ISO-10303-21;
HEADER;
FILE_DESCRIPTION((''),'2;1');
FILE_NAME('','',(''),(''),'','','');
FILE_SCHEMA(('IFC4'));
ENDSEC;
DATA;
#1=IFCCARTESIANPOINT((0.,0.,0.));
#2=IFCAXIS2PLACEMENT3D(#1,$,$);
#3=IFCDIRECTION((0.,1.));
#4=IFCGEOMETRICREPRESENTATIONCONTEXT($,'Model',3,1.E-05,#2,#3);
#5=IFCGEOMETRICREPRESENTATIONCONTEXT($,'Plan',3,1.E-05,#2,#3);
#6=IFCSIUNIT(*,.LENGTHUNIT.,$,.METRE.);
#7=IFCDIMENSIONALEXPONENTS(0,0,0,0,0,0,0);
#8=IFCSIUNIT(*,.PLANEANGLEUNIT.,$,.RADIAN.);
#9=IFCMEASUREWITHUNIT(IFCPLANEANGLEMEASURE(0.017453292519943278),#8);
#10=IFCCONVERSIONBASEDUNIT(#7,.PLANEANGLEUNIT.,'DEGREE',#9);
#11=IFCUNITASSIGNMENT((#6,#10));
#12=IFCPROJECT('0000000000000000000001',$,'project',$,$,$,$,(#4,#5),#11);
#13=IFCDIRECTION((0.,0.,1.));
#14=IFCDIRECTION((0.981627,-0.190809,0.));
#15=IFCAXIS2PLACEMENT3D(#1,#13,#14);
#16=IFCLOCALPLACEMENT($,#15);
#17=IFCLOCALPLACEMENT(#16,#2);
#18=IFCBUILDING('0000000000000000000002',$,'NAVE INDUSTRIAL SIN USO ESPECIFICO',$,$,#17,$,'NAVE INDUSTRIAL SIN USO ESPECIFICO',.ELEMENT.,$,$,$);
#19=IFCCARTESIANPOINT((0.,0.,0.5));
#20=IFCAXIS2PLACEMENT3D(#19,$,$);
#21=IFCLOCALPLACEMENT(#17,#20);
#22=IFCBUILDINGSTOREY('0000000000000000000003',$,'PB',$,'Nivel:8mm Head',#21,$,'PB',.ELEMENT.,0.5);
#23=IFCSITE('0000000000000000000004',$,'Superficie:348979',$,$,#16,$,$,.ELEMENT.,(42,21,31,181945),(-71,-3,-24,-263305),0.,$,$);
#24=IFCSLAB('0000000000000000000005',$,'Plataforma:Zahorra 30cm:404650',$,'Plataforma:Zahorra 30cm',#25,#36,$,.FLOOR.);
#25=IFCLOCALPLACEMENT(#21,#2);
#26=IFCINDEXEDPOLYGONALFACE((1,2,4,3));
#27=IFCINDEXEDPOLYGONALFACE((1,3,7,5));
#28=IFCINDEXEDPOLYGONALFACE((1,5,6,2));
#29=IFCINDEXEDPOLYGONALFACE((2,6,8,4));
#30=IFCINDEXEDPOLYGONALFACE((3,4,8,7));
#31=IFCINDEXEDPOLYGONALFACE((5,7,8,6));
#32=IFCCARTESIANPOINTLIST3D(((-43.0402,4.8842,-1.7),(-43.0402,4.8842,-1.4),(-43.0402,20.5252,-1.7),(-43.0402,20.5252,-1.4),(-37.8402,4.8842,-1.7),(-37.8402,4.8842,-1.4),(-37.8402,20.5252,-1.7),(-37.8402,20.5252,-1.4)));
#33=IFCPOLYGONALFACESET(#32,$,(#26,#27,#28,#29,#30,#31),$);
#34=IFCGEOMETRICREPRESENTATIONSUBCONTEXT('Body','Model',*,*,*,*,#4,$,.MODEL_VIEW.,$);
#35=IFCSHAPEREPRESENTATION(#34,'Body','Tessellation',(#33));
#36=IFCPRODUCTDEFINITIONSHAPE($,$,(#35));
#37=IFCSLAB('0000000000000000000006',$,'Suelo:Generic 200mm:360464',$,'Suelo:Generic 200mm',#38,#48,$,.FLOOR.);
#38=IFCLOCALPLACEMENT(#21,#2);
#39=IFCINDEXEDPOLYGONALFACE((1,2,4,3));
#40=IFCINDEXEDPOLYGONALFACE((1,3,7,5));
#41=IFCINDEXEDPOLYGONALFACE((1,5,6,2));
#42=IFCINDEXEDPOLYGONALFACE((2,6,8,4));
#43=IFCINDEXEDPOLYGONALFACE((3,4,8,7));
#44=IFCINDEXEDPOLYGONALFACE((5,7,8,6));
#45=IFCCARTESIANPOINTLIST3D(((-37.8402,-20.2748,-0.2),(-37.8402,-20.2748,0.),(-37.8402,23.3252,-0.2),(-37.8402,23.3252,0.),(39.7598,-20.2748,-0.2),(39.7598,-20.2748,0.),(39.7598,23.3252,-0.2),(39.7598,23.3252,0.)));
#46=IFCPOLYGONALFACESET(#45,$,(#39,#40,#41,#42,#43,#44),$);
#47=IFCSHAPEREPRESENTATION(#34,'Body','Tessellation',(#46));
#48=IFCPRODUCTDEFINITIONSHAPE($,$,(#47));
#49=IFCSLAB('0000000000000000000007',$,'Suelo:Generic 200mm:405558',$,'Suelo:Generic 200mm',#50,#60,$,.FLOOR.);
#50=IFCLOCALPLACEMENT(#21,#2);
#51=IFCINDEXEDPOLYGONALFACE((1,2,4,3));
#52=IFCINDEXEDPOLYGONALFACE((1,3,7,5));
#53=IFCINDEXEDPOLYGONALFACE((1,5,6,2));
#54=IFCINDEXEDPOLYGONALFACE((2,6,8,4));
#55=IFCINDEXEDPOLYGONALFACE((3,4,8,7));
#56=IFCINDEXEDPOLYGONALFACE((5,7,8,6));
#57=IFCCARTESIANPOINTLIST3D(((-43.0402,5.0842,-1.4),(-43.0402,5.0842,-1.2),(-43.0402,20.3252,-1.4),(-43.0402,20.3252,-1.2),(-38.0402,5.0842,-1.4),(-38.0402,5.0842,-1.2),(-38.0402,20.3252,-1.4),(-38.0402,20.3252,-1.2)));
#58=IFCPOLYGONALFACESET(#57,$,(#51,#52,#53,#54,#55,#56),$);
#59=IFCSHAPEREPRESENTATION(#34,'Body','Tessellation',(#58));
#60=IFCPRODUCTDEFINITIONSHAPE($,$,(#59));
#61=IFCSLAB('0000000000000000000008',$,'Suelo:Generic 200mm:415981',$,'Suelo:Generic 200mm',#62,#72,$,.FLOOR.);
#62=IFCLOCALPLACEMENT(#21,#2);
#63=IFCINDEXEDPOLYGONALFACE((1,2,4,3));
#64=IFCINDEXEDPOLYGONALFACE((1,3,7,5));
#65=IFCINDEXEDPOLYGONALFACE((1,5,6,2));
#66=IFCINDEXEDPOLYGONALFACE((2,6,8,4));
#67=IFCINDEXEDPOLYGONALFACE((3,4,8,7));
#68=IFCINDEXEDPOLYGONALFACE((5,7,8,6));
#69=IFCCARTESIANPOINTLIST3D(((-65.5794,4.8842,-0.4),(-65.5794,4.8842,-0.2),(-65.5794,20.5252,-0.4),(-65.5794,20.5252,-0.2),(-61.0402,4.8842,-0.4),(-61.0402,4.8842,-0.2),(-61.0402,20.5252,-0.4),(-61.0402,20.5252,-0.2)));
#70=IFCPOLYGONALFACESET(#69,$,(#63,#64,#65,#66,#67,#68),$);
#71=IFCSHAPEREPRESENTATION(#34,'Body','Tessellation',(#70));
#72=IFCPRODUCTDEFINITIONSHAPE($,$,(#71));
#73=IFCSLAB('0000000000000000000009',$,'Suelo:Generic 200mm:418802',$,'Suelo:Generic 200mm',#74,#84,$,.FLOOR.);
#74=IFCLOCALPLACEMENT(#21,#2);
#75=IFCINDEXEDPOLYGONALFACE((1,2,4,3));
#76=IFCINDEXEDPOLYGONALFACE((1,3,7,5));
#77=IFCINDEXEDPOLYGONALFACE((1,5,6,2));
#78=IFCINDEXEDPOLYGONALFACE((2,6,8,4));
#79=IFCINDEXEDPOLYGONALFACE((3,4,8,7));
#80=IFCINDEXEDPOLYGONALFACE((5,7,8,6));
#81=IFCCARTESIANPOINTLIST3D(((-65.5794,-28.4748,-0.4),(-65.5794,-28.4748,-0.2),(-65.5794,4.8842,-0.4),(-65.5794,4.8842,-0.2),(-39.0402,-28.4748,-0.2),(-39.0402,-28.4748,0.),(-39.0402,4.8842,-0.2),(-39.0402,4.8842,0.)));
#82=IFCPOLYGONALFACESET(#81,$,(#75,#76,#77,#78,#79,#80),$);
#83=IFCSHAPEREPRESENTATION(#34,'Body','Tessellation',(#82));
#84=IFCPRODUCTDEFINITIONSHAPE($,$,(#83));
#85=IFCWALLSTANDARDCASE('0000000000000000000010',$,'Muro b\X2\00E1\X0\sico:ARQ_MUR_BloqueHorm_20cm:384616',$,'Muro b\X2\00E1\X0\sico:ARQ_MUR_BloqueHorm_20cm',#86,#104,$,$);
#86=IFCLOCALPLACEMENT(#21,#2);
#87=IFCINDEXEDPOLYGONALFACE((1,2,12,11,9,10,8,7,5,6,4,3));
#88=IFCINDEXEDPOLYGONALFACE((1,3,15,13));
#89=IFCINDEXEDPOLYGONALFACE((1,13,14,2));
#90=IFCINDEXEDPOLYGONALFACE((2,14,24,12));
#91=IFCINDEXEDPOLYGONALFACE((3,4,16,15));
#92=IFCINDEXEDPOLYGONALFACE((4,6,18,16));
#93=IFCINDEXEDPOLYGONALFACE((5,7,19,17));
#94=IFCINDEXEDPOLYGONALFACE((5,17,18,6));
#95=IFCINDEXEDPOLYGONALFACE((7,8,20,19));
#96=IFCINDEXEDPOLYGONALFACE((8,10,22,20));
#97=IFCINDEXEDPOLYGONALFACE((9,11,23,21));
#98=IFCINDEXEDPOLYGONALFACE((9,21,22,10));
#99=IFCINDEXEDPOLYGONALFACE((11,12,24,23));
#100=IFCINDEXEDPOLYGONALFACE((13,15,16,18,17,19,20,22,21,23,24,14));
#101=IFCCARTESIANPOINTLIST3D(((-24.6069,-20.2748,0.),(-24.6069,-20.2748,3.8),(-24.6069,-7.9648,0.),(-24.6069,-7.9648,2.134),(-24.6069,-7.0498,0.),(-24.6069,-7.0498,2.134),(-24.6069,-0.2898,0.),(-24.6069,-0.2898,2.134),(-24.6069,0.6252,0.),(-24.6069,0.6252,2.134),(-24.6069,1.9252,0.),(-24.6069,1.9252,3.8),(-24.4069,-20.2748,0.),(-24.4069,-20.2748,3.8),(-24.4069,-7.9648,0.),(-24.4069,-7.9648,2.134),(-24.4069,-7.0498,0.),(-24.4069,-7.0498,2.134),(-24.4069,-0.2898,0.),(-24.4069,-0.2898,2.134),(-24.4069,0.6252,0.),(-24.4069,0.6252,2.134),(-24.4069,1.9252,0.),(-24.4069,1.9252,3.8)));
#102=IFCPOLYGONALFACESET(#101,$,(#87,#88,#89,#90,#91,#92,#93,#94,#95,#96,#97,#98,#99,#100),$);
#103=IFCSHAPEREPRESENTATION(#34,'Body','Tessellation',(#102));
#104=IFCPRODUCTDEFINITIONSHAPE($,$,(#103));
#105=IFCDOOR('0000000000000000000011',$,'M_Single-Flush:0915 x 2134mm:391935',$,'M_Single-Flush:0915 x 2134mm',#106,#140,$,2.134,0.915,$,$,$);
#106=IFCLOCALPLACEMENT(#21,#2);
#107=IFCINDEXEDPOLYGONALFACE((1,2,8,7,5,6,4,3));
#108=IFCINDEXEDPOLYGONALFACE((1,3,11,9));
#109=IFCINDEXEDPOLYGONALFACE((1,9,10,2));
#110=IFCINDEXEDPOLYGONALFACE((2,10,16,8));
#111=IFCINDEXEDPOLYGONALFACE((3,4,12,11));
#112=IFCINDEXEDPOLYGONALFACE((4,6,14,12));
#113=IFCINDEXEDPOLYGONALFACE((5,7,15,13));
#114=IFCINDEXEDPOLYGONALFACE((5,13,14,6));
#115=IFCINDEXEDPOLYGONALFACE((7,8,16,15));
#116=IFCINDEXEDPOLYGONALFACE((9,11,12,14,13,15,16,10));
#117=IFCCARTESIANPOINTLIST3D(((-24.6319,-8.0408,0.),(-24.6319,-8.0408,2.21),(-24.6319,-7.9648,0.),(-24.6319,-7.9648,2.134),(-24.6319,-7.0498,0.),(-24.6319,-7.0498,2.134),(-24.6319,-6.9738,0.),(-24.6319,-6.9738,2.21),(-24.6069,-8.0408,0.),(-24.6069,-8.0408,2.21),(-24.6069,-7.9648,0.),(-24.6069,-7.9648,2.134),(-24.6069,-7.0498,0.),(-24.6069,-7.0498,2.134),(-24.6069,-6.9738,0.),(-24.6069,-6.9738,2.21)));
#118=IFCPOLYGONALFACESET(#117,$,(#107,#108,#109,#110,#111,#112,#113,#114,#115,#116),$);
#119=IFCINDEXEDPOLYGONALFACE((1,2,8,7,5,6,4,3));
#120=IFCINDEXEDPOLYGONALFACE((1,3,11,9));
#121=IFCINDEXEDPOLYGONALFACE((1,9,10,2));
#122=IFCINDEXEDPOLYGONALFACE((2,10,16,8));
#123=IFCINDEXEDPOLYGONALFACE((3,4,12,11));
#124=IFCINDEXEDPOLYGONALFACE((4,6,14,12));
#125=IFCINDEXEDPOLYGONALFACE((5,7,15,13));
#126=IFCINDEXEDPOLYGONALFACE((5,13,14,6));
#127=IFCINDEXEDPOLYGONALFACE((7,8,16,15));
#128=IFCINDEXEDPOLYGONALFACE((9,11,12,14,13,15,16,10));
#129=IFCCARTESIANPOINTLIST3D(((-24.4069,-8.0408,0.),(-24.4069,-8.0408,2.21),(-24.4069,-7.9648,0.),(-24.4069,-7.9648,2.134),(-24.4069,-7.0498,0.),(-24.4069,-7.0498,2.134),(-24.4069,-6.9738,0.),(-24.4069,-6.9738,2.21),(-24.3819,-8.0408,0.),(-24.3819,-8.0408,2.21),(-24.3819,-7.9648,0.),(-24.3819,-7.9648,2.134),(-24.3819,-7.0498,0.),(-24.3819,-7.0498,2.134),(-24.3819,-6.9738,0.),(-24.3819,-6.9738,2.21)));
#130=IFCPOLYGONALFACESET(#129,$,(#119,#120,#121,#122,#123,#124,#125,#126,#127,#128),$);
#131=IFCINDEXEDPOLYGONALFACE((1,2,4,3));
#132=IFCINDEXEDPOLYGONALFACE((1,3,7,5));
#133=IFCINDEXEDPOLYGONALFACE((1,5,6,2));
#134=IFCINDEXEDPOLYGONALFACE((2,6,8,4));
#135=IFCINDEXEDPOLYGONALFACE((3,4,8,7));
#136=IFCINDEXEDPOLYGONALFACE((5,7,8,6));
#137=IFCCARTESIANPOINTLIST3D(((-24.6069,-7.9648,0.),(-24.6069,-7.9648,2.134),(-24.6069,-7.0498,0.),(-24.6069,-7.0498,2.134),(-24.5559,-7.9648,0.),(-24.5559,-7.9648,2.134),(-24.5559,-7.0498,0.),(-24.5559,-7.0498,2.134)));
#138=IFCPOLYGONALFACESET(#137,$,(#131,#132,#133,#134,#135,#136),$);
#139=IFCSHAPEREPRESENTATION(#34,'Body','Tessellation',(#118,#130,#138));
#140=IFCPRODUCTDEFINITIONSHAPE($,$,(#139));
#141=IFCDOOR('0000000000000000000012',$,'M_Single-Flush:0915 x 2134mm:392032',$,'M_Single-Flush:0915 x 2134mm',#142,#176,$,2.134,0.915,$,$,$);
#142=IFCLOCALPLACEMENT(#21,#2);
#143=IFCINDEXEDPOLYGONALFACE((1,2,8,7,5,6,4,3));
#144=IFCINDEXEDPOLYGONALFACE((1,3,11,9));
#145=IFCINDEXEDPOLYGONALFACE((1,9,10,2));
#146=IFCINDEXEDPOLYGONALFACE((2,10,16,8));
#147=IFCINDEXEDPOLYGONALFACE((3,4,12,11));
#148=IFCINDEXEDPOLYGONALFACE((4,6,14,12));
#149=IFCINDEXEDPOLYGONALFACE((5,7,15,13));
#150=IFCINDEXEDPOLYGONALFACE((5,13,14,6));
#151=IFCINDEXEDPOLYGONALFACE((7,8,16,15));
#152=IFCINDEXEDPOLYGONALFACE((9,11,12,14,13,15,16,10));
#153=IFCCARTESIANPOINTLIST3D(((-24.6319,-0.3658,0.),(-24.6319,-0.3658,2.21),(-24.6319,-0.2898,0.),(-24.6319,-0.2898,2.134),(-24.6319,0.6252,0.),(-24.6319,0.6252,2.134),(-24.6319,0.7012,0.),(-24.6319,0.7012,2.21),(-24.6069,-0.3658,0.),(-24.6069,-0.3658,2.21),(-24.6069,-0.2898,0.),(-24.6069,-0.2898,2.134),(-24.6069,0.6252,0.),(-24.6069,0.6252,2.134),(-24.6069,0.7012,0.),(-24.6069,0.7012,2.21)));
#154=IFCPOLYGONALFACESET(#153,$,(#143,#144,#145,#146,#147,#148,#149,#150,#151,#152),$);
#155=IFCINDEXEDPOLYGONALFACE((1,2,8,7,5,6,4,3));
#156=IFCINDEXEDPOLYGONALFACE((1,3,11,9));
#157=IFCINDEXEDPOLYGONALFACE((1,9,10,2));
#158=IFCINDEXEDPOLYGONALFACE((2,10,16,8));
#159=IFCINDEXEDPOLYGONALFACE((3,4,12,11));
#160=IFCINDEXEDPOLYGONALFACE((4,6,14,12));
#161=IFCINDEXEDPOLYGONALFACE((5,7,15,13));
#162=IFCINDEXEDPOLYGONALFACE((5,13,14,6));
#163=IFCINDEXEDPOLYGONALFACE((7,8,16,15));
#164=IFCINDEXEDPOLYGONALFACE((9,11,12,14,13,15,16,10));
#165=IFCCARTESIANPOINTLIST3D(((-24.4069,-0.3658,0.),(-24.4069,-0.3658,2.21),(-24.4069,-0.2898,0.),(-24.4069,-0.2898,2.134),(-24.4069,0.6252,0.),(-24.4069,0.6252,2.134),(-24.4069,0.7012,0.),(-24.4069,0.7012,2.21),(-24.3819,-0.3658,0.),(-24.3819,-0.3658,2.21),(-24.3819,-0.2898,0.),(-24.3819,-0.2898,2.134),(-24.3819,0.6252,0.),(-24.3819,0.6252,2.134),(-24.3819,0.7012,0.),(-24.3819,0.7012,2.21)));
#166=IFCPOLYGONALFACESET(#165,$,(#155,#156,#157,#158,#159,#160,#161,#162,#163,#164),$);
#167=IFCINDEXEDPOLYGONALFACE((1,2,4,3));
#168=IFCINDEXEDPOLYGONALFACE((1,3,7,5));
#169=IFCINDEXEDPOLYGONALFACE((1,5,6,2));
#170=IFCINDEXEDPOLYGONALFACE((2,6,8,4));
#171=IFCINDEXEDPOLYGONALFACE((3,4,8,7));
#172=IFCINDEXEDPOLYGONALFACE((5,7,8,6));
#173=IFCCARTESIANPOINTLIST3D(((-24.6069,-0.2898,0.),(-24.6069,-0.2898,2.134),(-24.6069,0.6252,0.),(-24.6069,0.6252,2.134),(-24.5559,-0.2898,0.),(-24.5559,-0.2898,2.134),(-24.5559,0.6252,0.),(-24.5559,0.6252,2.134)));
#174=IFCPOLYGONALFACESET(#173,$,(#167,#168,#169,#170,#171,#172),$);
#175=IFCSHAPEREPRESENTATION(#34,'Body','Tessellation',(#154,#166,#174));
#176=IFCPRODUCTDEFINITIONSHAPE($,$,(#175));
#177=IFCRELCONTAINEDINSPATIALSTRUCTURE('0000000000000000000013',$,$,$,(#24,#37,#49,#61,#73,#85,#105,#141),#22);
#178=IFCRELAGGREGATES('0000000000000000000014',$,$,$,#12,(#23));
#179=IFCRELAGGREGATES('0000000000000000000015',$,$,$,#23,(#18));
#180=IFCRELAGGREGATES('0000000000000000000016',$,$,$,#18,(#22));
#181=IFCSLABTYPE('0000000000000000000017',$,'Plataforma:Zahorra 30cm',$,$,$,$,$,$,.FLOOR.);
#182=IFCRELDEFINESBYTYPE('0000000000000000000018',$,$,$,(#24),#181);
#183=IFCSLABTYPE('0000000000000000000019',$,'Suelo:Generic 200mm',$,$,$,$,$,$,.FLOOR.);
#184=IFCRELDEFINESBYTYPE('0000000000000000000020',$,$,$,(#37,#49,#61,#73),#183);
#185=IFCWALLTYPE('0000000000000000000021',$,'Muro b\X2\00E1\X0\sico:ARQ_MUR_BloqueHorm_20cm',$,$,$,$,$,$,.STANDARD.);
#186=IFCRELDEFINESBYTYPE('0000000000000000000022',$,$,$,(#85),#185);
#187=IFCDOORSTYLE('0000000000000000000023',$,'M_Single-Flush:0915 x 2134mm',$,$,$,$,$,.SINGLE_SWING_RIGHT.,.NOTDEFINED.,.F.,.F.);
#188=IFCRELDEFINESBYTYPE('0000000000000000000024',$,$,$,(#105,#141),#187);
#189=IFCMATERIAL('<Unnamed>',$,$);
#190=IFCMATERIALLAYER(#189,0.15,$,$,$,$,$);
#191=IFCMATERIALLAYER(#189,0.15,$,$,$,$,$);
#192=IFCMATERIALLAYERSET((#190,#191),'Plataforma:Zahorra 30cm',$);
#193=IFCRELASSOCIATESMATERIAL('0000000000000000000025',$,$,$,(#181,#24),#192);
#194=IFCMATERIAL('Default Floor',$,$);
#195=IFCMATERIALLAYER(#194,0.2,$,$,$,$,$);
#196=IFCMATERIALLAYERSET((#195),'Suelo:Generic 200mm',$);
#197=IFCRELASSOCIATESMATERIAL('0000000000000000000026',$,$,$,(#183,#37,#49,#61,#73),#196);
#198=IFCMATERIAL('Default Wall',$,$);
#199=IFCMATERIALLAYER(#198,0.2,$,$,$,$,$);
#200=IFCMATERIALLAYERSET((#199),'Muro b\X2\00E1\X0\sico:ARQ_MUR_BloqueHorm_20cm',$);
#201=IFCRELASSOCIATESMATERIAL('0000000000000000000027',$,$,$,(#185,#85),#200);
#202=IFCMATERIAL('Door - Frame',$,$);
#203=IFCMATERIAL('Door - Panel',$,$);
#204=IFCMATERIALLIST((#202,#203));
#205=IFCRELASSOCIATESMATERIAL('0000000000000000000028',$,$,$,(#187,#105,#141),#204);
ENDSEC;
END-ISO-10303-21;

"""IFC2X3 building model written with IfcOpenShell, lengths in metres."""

from ifc_helpers import new_model, entity, si_unit, converted_unit, direction, frame, frame_2d, origin, origin_2d_with_axis, place, context, subcontext, project, spatial, polyline, rectangle, outline, extrude, clip, halfspace, source, transform, mapped, material, material_list, layer, layer_set, layer_usage, type_object, type_shapes, element, fill, save


model = new_model("IFC2X3")

# Units and contexts
model_context = context("Model", 3, precision=1e-05, world=origin(), true_north=direction((0.0, 1.0)))
plan_context = context("Plan", 3, precision=1e-05, world=origin(), true_north=direction((0.0, 1.0)))
body_context = subcontext(model_context, "Body", "Model", "MODEL_VIEW")
ifc_project = project(units=[si_unit("LENGTHUNIT", "METRE"), converted_unit("PLANEANGLEUNIT", "DEGREE", entity("IfcPlaneAngleMeasure", 0.017453292519943278), si_unit("PLANEANGLEUNIT", "RADIAN"), dimensions=[0, 0, 0, 0, 0, 0, 0])], contexts=[model_context, plan_context])

# Site, building, storey
site_placement = place(None, frame((0.0, 0.0, 0.0), z_axis=(0.0, 0.0, 1.0), x_axis=(0.981627, -0.190809, 0.0)))
site = spatial("IfcSite", under=ifc_project, at=site_placement, Name="Superficie:348979", CompositionType="ELEMENT", RefLatitude=(42, 21, 31, 181945), RefLongitude=(-71, -3, -24, -263305), RefElevation=0.0)
building_placement = place(site_placement, origin())
building = spatial("IfcBuilding", under=site, at=building_placement, Name="NAVE INDUSTRIAL SIN USO ESPECIFICO", LongName="NAVE INDUSTRIAL SIN USO ESPECIFICO", CompositionType="ELEMENT")
storey_placement = place(building_placement, frame((0.0, 0.0, 0.5)))
storey = spatial("IfcBuildingStorey", under=building, at=storey_placement, Name="PB", ObjectType="Nivel:8mm Head", LongName="PB", CompositionType="ELEMENT", Elevation=0.5)

# Slabs
ifc_material_1 = material(Name="<Unnamed>")
ifc_layer_1 = layer(ifc_material_1, 0.15)
ifc_layer_2 = layer(ifc_material_1, 0.15)
ifc_layer_set_1 = layer_set([ifc_layer_1, ifc_layer_2], Name="Plataforma:Zahorra 30cm")
slab_type_1 = type_object("IfcSlabType", Name="Plataforma:Zahorra 30cm", PredefinedType="FLOOR", material=ifc_layer_set_1)
ifc_layer_usage_1 = layer_usage(ifc_layer_set_1, "AXIS3", "NEGATIVE", 0.0)
slab_1_placement = place(storey_placement, origin())
element("IfcSlab", 1, at=slab_1_placement, inside=storey, type_object=slab_type_1, material=ifc_layer_usage_1, Name="Plataforma:Zahorra 30cm:404650", ObjectType="Plataforma:Zahorra 30cm", PredefinedType="FLOOR", context=body_context, shape_type="SweptSolid", body=[
    extrude(rectangle(XDim=15.641, YDim=5.2, at=frame_2d((0.0, 0.0), x_axis=(1.0, 0.0))), frame((-40.4402, 12.7047, -1.7), z_axis=(0.0, 0.0, 1.0), x_axis=(0.0, -1.0, 0.0)), (0.0, 0.0, 1.0), 0.3),
])
ifc_material_2 = material(Name="Default Floor")
ifc_layer_3 = layer(ifc_material_2, 0.2)
ifc_layer_set_2 = layer_set([ifc_layer_3], Name="Suelo:Generic 200mm")
ifc_layer_usage_2 = layer_usage(ifc_layer_set_2, "AXIS3", "POSITIVE", 0.0)
slab_type_2 = type_object("IfcSlabType", Name="Suelo:Generic 200mm", PredefinedType="FLOOR", material=ifc_layer_set_2)
slab_2_placement = place(storey_placement, origin())
element("IfcSlab", 2, at=slab_2_placement, inside=storey, type_object=slab_type_2, material=ifc_layer_usage_2, Name="Suelo:Generic 200mm:360464", ObjectType="Suelo:Generic 200mm", PredefinedType="FLOOR", context=body_context, shape_type="SweptSolid", body=[
    extrude(rectangle(XDim=43.6, YDim=77.6, at=origin_2d_with_axis()), frame((0.9598, 1.5252, 0.0), z_axis=(0.0, 0.0, -1.0), x_axis=(0.0, 1.0, 0.0)), (0.0, 0.0, 1.0), 0.2),
])
ifc_layer_usage_3 = layer_usage(ifc_layer_set_2, "AXIS3", "POSITIVE", 0.0)
slab_3_placement = place(storey_placement, origin())
element("IfcSlab", 3, at=slab_3_placement, inside=storey, type_object=slab_type_2, material=ifc_layer_usage_3, Name="Suelo:Generic 200mm:405558", ObjectType="Suelo:Generic 200mm", PredefinedType="FLOOR", context=body_context, shape_type="SweptSolid", body=[
    extrude(rectangle(XDim=15.241, YDim=5.0, at=frame_2d((0.0, 0.0), x_axis=(1.0, 0.0))), frame((-40.5402, 12.7047, -1.2), z_axis=(0.0, 0.0, -1.0), x_axis=(0.0, 1.0, 0.0)), (0.0, 0.0, 1.0), 0.2),
])
ifc_layer_usage_4 = layer_usage(ifc_layer_set_2, "AXIS3", "POSITIVE", 0.0)
slab_4_placement = place(storey_placement, origin())
element("IfcSlab", 4, at=slab_4_placement, inside=storey, type_object=slab_type_2, material=ifc_layer_usage_4, Name="Suelo:Generic 200mm:415981", ObjectType="Suelo:Generic 200mm", PredefinedType="FLOOR", context=body_context, shape_type="SweptSolid", body=[
    extrude(rectangle(XDim=15.641, YDim=4.5392, at=frame_2d((0.0, 0.0), x_axis=(1.0, 0.0))), frame((-63.3098, 12.7047, -0.2), z_axis=(0.0, 0.0, -1.0), x_axis=(0.0, 1.0, 0.0)), (0.0, 0.0, 1.0), 0.2),
])
ifc_layer_usage_5 = layer_usage(ifc_layer_set_2, "AXIS3", "POSITIVE", 0.0)
slab_5_placement = place(storey_placement, origin())
element("IfcSlab", 5, at=slab_5_placement, inside=storey, type_object=slab_type_2, material=ifc_layer_usage_5, Name="Suelo:Generic 200mm:418802", ObjectType="Suelo:Generic 200mm", PredefinedType="FLOOR", context=body_context, shape_type="SweptSolid", body=[
    clip(clip(extrude(rectangle(XDim=26.54, YDim=33.359, at=frame_2d((0.0, 0.0), x_axis=(0.0, 1.0))), frame((-52.3098, -11.7953, -0.1), z_axis=(0.007536, 0.0, -0.999972), x_axis=(0.0, 1.0, 0.0)), (0.0, -0.007536, 0.999972), 0.2), halfspace(frame((-52.3098, -11.7953, -0.3), z_axis=(0.007536, 0.0, -0.999972), x_axis=(-0.999972, 0.0, -0.007536)), False)), halfspace(frame((-52.3098, -11.7953, -0.1), z_axis=(-0.007536, 0.0, 0.999972), x_axis=(-0.999972, 0.0, -0.007536)), False)),
])

# Wall, openings, doors
ifc_material_3 = material(Name="Default Wall")
ifc_layer_4 = layer(ifc_material_3, 0.2)
ifc_layer_set_3 = layer_set([ifc_layer_4], Name="Muro básico:ARQ_MUR_BloqueHorm_20cm")
ifc_layer_usage_6 = layer_usage(ifc_layer_set_3, "AXIS2", "POSITIVE", -0.1)
wall_type = type_object("IfcWallType", Name="Muro básico:ARQ_MUR_BloqueHorm_20cm", PredefinedType="STANDARD", material=ifc_layer_set_3)
wall_1_placement = place(storey_placement, frame((-24.5069, -20.2748, 0.0), z_axis=(0.0, 0.0, 1.0), x_axis=(0.0, 1.0, 0.0)))
wall_1 = element("IfcWallStandardCase", 6, at=wall_1_placement, inside=storey, type_object=wall_type, material=ifc_layer_usage_6, Name="Muro básico:ARQ_MUR_BloqueHorm_20cm:384616", ObjectType="Muro básico:ARQ_MUR_BloqueHorm_20cm", context=body_context, shape_type="SweptSolid", body=[
    extrude(rectangle(XDim=22.2, YDim=0.2, at=frame_2d((11.1, 0.0), x_axis=(-1.0, 0.0))), origin(), (0.0, 0.0, 1.0), 3.8),
])
opening_1_placement = place(wall_1_placement, frame((12.31, -0.1, 0.0)))
opening_1 = element("IfcOpeningElement", 7, at=opening_1_placement, cuts=wall_1, ObjectType="Opening", context=body_context, shape_type="SweptSolid", body=[
    extrude(rectangle(XDim=0.915, YDim=2.134, at=frame_2d((1.067, 0.4575), x_axis=(0.0, 1.0))), frame((0.0, 0.0, 0.0), z_axis=(0.0, 1.0, 0.0), x_axis=(0.0, 0.0, 1.0)), (0.0, 0.0, 1.0), 0.2),
])
opening_2_placement = place(wall_1_placement, frame((19.985, -0.1, 0.0)))
opening_2 = element("IfcOpeningElement", 8, at=opening_2_placement, cuts=wall_1, ObjectType="Opening", context=body_context, shape_type="SweptSolid", body=[
    extrude(rectangle(XDim=0.915, YDim=2.134, at=frame_2d((1.067, 0.4575), x_axis=(0.0, 1.0))), frame((0.0, 0.0, 0.0), z_axis=(0.0, 1.0, 0.0), x_axis=(0.0, 0.0, 1.0)), (0.0, 0.0, 1.0), 0.2),
])
ifc_material_4 = material(Name="Door - Frame")
ifc_material_5 = material(Name="Door - Panel")
ifc_material_list = material_list([ifc_material_4, ifc_material_5])
door_style = type_object("IfcDoorStyle", Name="M_Single-Flush:0915 x 2134mm", ConstructionType="NOTDEFINED", OperationType="SINGLE_SWING_RIGHT", ParameterTakesPrecedence=False, Sizeable=False, material=ifc_material_list)
shared_shape_1 = source(origin(), body_context, "Body", "SweptSolid", [
    extrude(outline(polyline([(-0.5335, -1.124), (0.5335, -1.124), (0.5335, 1.086), (0.4575, 1.086), (0.4575, -1.048), (-0.4575, -1.048), (-0.4575, 1.086), (-0.5335, 1.086), (-0.5335, -1.124)])), frame((0.4575, 0.2, 1.086), z_axis=(0.0, 1.0, 0.0), x_axis=(1.0, 0.0, 0.0)), (0.0, 0.0, 1.0), 0.025),
    extrude(outline(polyline([(-1.124, -0.5335), (1.086, -0.5335), (1.086, -0.4575), (-1.048, -0.4575), (-1.048, 0.4575), (1.086, 0.4575), (1.086, 0.5335), (-1.124, 0.5335), (-1.124, -0.5335)])), frame((0.4575, -0.025, 1.086), z_axis=(0.0, 1.0, 0.0), x_axis=(0.0, 0.0, -1.0)), (0.0, 0.0, 1.0), 0.025),
    extrude(rectangle(XDim=0.051, YDim=0.915, at=frame_2d((0.0, 0.0), x_axis=(1.0, 0.0))), frame((0.4575, 0.1745, 0.0), z_axis=(0.0, 0.0, 1.0), x_axis=(0.0, 1.0, 0.0)), (0.0, 0.0, 1.0), 2.134),
])
type_shapes(door_style, [shared_shape_1])
door_1_placement = place(opening_1_placement, origin())
door_1 = element("IfcDoor", 9, at=door_1_placement, inside=storey, type_object=door_style, material=ifc_material_list, Name="M_Single-Flush:0915 x 2134mm:391935", ObjectType="M_Single-Flush:0915 x 2134mm", OverallHeight=2.134, OverallWidth=0.915, context=body_context, shape_type="MappedRepresentation", body=[
    mapped(shared_shape_1, transform((0.0, 0.0, 0.0), scale=1.0)),
])
fill(opening_1, door_1)
door_2_placement = place(opening_2_placement, origin())
door_2 = element("IfcDoor", 10, at=door_2_placement, inside=storey, type_object=door_style, material=ifc_material_list, Name="M_Single-Flush:0915 x 2134mm:392032", ObjectType="M_Single-Flush:0915 x 2134mm", OverallHeight=2.134, OverallWidth=0.915, context=body_context, shape_type="MappedRepresentation", body=[
    mapped(shared_shape_1, transform((0.0, 0.0, 0.0), scale=1.0)),
])
fill(opening_2, door_2)

save(model, "model.ifc")
